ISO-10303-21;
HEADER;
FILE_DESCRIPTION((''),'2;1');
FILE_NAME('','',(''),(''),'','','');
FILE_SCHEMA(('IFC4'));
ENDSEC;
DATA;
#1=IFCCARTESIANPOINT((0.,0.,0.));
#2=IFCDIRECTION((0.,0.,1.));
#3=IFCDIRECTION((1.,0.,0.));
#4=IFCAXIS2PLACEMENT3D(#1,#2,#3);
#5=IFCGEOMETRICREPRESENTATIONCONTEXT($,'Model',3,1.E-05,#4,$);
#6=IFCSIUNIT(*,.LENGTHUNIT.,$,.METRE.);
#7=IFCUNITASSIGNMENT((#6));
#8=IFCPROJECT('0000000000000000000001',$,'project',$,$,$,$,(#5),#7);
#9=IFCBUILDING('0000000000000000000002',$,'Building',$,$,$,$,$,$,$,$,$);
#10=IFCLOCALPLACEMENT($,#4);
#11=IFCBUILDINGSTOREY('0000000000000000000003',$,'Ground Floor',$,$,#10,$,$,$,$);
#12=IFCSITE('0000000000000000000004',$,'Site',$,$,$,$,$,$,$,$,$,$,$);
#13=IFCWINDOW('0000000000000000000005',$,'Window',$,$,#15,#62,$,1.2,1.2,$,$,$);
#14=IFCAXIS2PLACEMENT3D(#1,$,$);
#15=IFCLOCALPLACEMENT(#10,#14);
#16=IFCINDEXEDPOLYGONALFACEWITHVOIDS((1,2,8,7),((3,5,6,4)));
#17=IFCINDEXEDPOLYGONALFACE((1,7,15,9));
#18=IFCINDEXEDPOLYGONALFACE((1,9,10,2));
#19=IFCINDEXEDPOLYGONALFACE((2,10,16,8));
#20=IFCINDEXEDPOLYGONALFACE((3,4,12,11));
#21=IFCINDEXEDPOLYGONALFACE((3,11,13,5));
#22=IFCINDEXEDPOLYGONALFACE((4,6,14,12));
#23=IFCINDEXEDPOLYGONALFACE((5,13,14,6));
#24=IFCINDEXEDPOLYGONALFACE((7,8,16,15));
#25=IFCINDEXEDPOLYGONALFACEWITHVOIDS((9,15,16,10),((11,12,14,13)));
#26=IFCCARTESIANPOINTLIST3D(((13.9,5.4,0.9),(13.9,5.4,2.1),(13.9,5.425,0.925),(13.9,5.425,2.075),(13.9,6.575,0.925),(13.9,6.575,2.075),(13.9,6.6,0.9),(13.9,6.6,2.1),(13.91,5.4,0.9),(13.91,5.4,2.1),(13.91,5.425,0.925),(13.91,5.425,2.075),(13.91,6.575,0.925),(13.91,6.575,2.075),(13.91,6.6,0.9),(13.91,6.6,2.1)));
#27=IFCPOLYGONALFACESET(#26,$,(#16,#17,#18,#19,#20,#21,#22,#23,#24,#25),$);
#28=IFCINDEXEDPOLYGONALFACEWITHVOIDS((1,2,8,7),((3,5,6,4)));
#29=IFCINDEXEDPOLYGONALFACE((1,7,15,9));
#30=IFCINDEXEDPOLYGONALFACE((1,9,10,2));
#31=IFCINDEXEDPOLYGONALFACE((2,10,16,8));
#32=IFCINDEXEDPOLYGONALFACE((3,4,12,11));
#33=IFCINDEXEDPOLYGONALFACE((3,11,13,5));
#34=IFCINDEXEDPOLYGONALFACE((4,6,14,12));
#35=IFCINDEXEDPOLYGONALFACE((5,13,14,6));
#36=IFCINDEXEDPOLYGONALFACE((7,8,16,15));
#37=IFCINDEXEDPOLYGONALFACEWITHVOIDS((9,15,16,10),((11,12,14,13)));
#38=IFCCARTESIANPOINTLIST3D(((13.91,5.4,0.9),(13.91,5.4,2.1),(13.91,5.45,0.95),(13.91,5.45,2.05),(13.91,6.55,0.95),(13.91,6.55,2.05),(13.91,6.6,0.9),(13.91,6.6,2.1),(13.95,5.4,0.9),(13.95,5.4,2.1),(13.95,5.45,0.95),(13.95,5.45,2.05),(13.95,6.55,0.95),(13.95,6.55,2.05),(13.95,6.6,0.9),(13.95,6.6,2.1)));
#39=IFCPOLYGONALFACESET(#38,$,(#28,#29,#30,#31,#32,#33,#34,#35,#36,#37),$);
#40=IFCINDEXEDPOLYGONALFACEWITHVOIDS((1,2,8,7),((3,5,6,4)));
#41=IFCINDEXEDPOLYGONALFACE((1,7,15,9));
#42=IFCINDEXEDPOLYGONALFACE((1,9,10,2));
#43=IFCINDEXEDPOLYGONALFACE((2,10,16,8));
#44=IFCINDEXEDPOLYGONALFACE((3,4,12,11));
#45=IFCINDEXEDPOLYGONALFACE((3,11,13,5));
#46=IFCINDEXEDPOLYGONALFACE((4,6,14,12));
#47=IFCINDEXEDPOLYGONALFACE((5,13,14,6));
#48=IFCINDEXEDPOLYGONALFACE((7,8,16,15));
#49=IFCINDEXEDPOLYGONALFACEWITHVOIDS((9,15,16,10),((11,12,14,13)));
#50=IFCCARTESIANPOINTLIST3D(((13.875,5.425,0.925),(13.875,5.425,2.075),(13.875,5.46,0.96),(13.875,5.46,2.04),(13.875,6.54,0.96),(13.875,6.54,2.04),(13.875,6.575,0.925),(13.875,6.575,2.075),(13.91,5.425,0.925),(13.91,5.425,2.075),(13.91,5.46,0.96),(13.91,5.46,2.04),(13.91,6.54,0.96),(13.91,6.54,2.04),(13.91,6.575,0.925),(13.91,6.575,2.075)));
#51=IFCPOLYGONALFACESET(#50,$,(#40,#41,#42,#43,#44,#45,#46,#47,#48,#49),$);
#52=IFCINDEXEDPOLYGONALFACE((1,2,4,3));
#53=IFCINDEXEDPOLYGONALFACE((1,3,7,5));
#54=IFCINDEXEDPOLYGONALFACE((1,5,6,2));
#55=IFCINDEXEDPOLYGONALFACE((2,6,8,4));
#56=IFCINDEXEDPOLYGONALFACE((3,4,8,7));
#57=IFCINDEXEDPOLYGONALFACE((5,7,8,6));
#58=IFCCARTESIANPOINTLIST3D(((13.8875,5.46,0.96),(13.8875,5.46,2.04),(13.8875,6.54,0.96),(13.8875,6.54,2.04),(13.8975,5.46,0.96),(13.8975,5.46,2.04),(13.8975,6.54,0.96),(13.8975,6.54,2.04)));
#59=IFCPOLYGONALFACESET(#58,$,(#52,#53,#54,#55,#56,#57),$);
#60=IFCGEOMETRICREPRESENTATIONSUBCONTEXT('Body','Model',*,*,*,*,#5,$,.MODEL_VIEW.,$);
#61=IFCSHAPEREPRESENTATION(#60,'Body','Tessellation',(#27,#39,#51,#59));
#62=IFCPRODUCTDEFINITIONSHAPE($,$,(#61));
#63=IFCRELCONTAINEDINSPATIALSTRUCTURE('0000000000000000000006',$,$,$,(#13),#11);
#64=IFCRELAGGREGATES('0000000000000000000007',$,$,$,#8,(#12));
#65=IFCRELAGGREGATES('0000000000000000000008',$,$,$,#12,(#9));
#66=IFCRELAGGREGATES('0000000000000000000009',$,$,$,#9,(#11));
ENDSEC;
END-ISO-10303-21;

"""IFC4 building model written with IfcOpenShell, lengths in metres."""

from ifc_helpers import new_model, si_unit, frame, origin_with_axes, place, context, subcontext, project, spatial, line, indexed_curve, outline, extrude, element, save


model = new_model("IFC4")

# Units and contexts
model_context = context("Model", 3, precision=1e-05, world=origin_with_axes())
body_context = subcontext(model_context, "Body", "Model", "MODEL_VIEW")
ifc_project = project(units=[si_unit("LENGTHUNIT", "METRE")], contexts=[model_context])

# Site, building, storey
site = spatial("IfcSite", under=ifc_project, Name="Site")
building = spatial("IfcBuilding", under=site, Name="Building")
storey_placement = place(None, origin_with_axes())
storey = spatial("IfcBuildingStorey", under=building, at=storey_placement, Name="Ground Floor")

# Window
window_1_placement = place(storey_placement, frame((14.0, 5.4, 0.9), z_axis=(0.0, 0.0, 1.0), x_axis=(0.0, 1.0, 0.0)))
element("IfcWindow", 1, at=window_1_placement, inside=storey, Name="Window", OverallHeight=1.2, OverallWidth=1.2, context=body_context, shape_type="SweptSolid", body=[
    extrude(outline(indexed_curve([(0.0, 0.0), (1.2, 0.0), (1.2, 1.2), (0.0, 1.2)], segments=[line(1, 2, 3, 4, 1)]), holes=[indexed_curve([(0.025, 0.025), (1.175, 0.025), (1.175, 1.175), (0.025, 1.175)], segments=[line(1, 2, 3, 4, 1)])]), frame((0.0, 0.09, 0.0), z_axis=(0.0, -1.0, 0.0), x_axis=(1.0, 0.0, 0.0)), (0.0, 0.0, -1.0), 0.01),
    extrude(outline(indexed_curve([(0.0, 0.0), (1.2, 0.0), (1.2, 1.2), (0.0, 1.2)], segments=[line(1, 2, 3, 4, 1)]), holes=[indexed_curve([(0.05, 0.05), (1.15, 0.05), (1.15, 1.15), (0.05, 1.15)], segments=[line(1, 2, 3, 4, 1)])]), frame((0.0, 0.05, 0.0), z_axis=(0.0, -1.0, 0.0), x_axis=(1.0, 0.0, 0.0)), (0.0, 0.0, -1.0), 0.04),
    extrude(outline(indexed_curve([(0.0, 0.0), (1.15, 0.0), (1.15, 1.15), (0.0, 1.15)], segments=[line(1, 2, 3, 4, 1)]), holes=[indexed_curve([(0.035, 0.035), (1.115, 0.035), (1.115, 1.115), (0.035, 1.115)], segments=[line(1, 2, 3, 4, 1)])]), frame((0.025, 0.09, 0.025), z_axis=(0.0, -1.0, 0.0), x_axis=(1.0, 0.0, 0.0)), (0.0, 0.0, -1.0), 0.035),
    extrude(outline(indexed_curve([(0.035, 0.035), (1.115, 0.035), (1.115, 1.115), (0.035, 1.115)], segments=[line(1, 2, 3, 4, 1)])), frame((0.025, 0.1025, 0.025), z_axis=(0.0, -1.0, 0.0), x_axis=(1.0, 0.0, 0.0)), (0.0, 0.0, -1.0), 0.01),
])

save(model, "model.ifc")
